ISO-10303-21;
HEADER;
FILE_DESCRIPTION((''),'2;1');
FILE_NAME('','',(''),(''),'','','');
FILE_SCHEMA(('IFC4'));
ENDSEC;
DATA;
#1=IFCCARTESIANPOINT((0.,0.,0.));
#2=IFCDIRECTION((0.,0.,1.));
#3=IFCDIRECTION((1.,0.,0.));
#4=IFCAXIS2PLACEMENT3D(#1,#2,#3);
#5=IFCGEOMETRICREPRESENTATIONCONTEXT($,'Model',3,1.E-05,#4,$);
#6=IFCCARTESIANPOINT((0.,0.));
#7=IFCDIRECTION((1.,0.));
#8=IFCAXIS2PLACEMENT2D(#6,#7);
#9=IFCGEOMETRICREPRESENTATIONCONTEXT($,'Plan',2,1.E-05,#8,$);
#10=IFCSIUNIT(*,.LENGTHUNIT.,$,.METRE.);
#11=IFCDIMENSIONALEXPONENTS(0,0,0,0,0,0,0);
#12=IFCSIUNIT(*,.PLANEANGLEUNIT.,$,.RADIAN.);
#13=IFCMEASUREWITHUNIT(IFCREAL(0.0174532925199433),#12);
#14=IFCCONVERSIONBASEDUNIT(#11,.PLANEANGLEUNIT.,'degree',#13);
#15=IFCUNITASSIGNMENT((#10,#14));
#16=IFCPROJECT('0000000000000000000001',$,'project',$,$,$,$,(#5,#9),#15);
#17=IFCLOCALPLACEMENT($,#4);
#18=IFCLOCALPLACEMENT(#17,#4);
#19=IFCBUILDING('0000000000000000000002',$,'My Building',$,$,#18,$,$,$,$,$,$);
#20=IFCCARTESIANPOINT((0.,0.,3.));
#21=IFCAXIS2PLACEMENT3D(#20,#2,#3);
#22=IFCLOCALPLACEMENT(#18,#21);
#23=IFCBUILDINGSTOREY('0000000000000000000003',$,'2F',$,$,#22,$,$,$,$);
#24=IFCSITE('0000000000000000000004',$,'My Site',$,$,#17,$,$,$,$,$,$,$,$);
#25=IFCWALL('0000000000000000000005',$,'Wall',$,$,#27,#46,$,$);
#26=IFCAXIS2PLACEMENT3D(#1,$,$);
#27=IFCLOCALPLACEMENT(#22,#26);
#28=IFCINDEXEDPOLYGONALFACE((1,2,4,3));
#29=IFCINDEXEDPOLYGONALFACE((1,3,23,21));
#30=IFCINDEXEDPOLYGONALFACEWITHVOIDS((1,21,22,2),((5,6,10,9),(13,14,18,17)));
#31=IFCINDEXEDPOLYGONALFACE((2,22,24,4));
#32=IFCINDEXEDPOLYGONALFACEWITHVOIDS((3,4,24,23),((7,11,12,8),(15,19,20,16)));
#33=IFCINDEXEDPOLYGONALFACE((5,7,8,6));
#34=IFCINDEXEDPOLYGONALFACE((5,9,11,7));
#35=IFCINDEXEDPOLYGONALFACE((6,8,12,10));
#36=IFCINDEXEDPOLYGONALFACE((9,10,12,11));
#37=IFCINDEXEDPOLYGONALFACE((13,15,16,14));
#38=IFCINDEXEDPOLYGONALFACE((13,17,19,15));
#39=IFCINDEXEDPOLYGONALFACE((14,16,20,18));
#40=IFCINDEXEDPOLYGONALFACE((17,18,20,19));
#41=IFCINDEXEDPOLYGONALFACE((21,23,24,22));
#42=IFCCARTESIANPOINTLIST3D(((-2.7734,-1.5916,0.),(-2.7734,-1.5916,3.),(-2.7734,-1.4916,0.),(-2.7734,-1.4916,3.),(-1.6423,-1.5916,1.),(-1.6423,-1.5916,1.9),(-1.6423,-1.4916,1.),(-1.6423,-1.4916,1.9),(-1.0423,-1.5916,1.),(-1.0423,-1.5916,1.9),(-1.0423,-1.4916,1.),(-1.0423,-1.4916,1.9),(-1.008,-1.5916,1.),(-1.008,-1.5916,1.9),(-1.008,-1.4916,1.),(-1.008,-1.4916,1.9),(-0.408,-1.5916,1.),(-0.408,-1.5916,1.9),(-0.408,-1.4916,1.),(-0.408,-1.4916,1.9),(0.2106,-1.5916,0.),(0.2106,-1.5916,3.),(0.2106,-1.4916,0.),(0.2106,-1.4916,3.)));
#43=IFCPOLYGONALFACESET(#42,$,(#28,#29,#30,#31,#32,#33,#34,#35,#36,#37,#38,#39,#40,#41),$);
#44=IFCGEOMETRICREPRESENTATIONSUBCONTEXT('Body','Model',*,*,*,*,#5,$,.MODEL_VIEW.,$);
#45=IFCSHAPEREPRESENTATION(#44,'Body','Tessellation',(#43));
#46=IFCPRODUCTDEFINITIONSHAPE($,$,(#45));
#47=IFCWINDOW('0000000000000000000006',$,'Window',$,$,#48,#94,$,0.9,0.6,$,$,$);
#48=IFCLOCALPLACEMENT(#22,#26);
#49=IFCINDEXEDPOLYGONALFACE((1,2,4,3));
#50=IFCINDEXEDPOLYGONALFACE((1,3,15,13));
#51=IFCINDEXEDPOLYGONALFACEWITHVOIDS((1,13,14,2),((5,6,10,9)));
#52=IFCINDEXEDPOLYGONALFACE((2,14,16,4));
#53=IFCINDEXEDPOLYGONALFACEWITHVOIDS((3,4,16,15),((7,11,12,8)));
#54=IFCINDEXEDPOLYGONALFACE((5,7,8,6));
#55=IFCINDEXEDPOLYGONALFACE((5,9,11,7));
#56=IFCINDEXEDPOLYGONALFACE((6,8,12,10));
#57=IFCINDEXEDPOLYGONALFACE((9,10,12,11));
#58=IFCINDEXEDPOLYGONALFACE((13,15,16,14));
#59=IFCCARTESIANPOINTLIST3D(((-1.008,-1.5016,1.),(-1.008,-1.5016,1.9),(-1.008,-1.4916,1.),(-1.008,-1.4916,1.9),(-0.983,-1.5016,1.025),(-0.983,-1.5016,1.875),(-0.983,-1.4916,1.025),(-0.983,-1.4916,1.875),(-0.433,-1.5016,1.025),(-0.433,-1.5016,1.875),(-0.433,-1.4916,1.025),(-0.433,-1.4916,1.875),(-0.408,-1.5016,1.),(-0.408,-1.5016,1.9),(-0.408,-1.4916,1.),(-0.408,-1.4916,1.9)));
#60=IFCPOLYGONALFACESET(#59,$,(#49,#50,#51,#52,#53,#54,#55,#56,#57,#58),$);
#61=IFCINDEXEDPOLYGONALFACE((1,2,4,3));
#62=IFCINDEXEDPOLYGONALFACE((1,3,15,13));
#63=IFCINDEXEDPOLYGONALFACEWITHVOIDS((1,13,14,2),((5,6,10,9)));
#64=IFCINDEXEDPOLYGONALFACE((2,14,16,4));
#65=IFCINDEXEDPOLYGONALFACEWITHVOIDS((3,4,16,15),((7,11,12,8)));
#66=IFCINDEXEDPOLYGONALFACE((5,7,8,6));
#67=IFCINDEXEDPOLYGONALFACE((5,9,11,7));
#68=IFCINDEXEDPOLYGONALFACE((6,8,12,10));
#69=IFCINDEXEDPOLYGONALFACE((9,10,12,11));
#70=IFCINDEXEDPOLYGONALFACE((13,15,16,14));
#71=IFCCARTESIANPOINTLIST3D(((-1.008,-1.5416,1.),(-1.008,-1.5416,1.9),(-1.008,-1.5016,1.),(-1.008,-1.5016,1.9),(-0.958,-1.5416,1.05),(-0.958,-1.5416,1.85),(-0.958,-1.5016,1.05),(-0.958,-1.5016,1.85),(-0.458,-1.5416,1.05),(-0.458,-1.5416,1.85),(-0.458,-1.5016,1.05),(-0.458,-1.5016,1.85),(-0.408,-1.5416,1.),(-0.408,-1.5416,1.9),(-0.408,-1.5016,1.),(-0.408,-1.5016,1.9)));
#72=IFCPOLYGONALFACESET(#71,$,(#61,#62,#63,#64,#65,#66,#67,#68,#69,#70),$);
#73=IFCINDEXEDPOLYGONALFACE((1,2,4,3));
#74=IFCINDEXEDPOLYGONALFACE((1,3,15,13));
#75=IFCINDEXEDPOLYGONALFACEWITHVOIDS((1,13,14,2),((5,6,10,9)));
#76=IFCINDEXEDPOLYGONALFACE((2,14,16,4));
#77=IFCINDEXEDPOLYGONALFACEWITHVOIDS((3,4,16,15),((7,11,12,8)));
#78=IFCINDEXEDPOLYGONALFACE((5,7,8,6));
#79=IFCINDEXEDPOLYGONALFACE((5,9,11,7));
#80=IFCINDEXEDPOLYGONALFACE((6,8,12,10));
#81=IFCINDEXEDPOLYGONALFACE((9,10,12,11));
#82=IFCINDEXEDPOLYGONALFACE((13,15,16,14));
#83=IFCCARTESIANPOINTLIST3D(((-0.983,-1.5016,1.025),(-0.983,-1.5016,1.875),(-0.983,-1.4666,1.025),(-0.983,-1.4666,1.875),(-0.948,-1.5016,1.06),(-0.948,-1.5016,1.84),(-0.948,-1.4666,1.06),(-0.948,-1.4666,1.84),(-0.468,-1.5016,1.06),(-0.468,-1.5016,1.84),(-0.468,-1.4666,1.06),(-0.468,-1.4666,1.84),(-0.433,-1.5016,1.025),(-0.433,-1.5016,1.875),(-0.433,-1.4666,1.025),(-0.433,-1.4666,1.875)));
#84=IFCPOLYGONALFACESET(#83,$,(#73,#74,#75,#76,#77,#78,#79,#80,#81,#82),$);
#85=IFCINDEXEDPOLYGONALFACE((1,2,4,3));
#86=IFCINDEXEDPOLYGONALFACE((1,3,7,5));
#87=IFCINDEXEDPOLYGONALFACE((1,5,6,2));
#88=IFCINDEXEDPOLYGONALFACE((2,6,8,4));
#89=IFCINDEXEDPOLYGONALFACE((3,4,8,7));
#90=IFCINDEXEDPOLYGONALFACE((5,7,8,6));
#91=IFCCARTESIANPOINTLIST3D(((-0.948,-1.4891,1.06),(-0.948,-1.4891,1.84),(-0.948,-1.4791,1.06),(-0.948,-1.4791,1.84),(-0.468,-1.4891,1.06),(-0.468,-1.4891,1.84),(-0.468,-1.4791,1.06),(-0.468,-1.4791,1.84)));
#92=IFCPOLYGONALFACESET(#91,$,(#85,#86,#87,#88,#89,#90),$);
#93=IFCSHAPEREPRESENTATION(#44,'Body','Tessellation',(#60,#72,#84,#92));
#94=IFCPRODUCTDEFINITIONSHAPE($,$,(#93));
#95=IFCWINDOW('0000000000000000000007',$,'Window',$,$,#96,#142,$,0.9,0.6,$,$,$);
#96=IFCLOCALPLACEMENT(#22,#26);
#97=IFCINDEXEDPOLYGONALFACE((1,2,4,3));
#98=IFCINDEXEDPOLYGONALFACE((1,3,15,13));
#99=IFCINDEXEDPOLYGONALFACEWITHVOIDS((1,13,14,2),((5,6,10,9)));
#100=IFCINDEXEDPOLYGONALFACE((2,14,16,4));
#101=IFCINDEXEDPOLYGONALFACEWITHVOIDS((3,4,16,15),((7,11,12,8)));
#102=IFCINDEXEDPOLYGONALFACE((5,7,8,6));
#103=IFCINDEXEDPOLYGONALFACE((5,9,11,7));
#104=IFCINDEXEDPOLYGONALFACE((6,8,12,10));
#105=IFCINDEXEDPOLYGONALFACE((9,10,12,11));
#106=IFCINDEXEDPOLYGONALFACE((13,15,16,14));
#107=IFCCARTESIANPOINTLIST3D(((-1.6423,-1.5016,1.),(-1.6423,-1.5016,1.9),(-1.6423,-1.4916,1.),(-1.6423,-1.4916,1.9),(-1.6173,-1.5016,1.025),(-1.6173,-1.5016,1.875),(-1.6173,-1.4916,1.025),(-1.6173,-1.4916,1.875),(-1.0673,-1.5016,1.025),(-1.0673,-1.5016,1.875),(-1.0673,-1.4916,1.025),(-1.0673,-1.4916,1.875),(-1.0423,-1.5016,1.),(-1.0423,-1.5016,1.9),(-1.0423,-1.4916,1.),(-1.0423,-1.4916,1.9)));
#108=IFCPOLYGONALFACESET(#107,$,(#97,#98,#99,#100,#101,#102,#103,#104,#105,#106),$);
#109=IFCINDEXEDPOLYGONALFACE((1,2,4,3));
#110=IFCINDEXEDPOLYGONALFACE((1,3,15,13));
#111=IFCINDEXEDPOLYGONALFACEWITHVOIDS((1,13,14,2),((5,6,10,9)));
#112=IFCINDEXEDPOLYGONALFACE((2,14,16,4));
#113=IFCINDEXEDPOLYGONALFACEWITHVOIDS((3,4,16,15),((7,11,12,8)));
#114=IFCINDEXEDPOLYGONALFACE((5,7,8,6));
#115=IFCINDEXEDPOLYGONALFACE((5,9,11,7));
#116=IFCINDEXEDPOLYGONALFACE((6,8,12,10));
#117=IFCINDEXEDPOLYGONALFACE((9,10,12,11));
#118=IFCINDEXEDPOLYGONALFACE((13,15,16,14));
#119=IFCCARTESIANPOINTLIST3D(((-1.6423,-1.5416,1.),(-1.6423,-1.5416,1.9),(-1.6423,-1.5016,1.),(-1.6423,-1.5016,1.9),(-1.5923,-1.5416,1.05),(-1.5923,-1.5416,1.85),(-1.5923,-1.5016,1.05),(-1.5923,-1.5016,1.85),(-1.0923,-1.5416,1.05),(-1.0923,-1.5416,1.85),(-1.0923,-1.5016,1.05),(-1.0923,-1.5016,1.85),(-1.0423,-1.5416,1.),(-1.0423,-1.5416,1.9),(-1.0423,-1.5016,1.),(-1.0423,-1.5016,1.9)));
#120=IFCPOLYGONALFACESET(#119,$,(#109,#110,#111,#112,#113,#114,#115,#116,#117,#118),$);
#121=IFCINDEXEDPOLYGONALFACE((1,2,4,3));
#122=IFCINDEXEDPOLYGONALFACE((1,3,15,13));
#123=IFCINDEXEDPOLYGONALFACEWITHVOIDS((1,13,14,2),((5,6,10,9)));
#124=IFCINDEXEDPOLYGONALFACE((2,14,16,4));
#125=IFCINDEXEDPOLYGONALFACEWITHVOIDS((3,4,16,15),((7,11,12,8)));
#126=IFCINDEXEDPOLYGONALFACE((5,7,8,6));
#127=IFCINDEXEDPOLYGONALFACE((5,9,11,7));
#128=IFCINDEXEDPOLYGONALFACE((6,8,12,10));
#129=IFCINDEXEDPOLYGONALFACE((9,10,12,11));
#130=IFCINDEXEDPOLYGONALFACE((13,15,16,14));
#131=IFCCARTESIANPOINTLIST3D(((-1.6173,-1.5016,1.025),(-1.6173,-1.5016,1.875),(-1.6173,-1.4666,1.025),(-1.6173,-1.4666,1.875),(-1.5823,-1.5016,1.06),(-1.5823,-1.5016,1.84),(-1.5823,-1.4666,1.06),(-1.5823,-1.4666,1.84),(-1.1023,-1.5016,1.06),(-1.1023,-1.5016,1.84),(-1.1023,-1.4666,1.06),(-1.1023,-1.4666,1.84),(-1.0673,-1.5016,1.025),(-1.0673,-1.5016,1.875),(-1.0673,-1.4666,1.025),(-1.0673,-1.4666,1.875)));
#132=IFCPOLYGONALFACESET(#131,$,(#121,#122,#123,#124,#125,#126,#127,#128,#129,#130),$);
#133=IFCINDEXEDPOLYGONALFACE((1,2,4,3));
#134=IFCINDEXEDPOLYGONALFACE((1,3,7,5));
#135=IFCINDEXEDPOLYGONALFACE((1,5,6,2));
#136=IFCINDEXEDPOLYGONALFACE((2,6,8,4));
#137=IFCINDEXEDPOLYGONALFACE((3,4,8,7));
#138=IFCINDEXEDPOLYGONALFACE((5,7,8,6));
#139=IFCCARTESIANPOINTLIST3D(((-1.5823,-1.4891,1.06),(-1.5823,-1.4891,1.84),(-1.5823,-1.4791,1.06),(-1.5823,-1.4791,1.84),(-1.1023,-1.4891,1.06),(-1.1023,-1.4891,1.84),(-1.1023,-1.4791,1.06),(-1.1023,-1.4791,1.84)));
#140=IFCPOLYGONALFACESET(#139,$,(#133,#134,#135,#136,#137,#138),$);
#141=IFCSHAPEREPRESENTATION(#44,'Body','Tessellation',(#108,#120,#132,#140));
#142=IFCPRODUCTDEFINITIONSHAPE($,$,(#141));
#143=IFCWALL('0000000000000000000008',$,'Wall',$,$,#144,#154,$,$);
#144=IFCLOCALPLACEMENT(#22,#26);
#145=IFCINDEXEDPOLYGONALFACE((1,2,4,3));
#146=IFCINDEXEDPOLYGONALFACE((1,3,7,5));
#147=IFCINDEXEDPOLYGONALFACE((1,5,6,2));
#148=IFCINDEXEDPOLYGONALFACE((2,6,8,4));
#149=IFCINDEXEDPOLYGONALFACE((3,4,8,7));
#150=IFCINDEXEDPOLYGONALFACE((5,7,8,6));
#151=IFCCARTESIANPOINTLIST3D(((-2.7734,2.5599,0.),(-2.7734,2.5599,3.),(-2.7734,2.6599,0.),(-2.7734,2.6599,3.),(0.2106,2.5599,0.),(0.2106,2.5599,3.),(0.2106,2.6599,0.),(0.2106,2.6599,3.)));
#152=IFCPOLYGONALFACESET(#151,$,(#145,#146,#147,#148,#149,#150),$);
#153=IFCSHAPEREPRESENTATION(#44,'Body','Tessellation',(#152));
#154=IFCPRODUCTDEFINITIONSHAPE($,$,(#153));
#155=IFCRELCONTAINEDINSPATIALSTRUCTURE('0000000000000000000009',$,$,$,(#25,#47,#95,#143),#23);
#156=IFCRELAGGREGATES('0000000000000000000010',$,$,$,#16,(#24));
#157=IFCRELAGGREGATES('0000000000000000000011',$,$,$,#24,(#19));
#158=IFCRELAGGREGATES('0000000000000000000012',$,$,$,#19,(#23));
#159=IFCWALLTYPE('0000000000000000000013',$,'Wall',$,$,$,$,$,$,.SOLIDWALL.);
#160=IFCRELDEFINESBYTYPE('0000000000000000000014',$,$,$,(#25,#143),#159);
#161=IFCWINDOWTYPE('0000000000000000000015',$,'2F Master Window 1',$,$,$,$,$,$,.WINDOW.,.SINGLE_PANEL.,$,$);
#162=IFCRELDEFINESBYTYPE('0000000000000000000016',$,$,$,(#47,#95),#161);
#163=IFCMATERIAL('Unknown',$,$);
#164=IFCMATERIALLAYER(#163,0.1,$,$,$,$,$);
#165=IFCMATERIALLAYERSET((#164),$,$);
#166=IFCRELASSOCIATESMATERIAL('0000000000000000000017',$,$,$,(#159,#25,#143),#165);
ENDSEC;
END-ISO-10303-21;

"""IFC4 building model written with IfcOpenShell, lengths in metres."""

from ifc_helpers import new_model, entity, si_unit, converted_unit, frame, origin_with_axes, origin_2d_with_axis, place, context, subcontext, project, spatial, line, indexed_curve, outline, extrude, shape, source, transform, mapped, material, layer, layer_set, layer_usage, type_object, type_shapes, element, fill, save


model = new_model("IFC4")

# Units and contexts
model_context = context("Model", 3, precision=1e-05, world=origin_with_axes())
plan_context = context("Plan", 2, precision=1e-05, world=origin_2d_with_axis())
body_context_1 = subcontext(model_context, "Body", "Model", "MODEL_VIEW")
body_context_2 = subcontext(plan_context, "Body", "Plan", "PLAN_VIEW")
ifc_project = project(units=[si_unit("LENGTHUNIT", "METRE"), converted_unit("PLANEANGLEUNIT", "degree", entity("IfcReal", 0.0174532925199433), si_unit("PLANEANGLEUNIT", "RADIAN"), dimensions=[0, 0, 0, 0, 0, 0, 0])], contexts=[model_context, plan_context])

# Site, building, storey
site_placement = place(None, origin_with_axes())
site = spatial("IfcSite", under=ifc_project, at=site_placement, Name="My Site")
building_placement = place(site_placement, origin_with_axes())
building = spatial("IfcBuilding", under=site, at=building_placement, Name="My Building")
storey_placement = place(building_placement, frame((0.0, 0.0, 3.0), z_axis=(0.0, 0.0, 1.0), x_axis=(1.0, 0.0, 0.0)))
storey = spatial("IfcBuildingStorey", under=building, at=storey_placement, Name="2F")

# Shared definitions
ifc_material = material(Name="Unknown")

# Shared definitions
ifc_layer = layer(ifc_material, 0.1)
ifc_layer_set = layer_set([ifc_layer])
wall_type = type_object("IfcWallType", Name="Wall", PredefinedType="SOLIDWALL", material=ifc_layer_set)

# Wall, openings, windows
ifc_layer_usage_1 = layer_usage(ifc_layer_set, "AXIS2", "POSITIVE", 0.0)
wall_1_placement = place(storey_placement, frame((-2.7734, -1.5916, 0.0), z_axis=(0.0, 0.0, 1.0), x_axis=(1.0, 0.0, 0.0)))
wall_1 = element("IfcWall", 1, at=wall_1_placement, inside=storey, type_object=wall_type, material=ifc_layer_usage_1, Name="Wall", context=body_context_1, shape_type="SweptSolid", body=[
    extrude(outline(indexed_curve([(0.0, 0.0), (0.0, 0.1), (2.984, 0.1), (2.984, 0.0)], segments=[line(1, 2, 3, 4, 1)])), origin_with_axes(), (0.0, 0.0, 1.0), 3.0),
])
shared_shape_1 = source(origin_with_axes(), body_context_1, "Body", "SweptSolid", [
    extrude(outline(indexed_curve([(0.0, 0.0), (0.6, 0.0), (0.6, 0.9), (0.0, 0.9)], segments=[line(1, 2, 3, 4, 1)])), frame((0.0, -0.6, 0.0), z_axis=(0.0, -1.0, 0.0), x_axis=(1.0, 0.0, 0.0)), (0.0, 0.0, -1.0), 1.2),
])
opening_1_placement = place(wall_1_placement, frame((1.7654, 0.0, 1.0), z_axis=(0.0, 0.0, 1.0), x_axis=(1.0, 0.0, 0.0)))
opening_1 = element("IfcOpeningElement", 2, at=opening_1_placement, cuts=wall_1, PredefinedType="OPENING", context=body_context_1, shape_type="MappedRepresentation", body=[
    mapped(shared_shape_1, transform((0.0, 0.0, 0.0), x_axis=(1.0, 0.0, 0.0), y_axis=(0.0, 1.0, 0.0), z_axis=(0.0, 0.0, 1.0), scale=1.0)),
])
opening_2_placement = place(wall_1_placement, frame((1.1311, 0.0, 1.0), z_axis=(0.0, 0.0, 1.0), x_axis=(1.0, 0.0, 0.0)))
opening_2 = element("IfcOpeningElement", 3, at=opening_2_placement, cuts=wall_1, PredefinedType="OPENING", context=body_context_1, shape_type="MappedRepresentation", body=[
    mapped(shared_shape_1, transform((0.0, 0.0, 0.0), x_axis=(1.0, 0.0, 0.0), y_axis=(0.0, 1.0, 0.0), z_axis=(0.0, 0.0, 1.0), scale=1.0)),
])
window_type_1 = type_object("IfcWindowType", Name="2F Master Window 1", PartitioningType="SINGLE_PANEL", PredefinedType="WINDOW")
shared_shape_2 = source(origin_with_axes(), body_context_1, "Body", "SweptSolid", [
    extrude(outline(indexed_curve([(0.0, 0.0), (0.6, 0.0), (0.6, 0.9), (0.0, 0.9)], segments=[line(1, 2, 3, 4, 1)]), holes=[indexed_curve([(0.025, 0.025), (0.575, 0.025), (0.575, 0.875), (0.025, 0.875)], segments=[line(1, 2, 3, 4, 1)])]), frame((0.0, 0.09, 0.0), z_axis=(0.0, -1.0, 0.0), x_axis=(1.0, 0.0, 0.0)), (0.0, 0.0, -1.0), 0.01),
    extrude(outline(indexed_curve([(0.0, 0.0), (0.6, 0.0), (0.6, 0.9), (0.0, 0.9)], segments=[line(1, 2, 3, 4, 1)]), holes=[indexed_curve([(0.05, 0.05), (0.55, 0.05), (0.55, 0.85), (0.05, 0.85)], segments=[line(1, 2, 3, 4, 1)])]), frame((0.0, 0.05, 0.0), z_axis=(0.0, -1.0, 0.0), x_axis=(1.0, 0.0, 0.0)), (0.0, 0.0, -1.0), 0.04),
    extrude(outline(indexed_curve([(0.0, 0.0), (0.55, 0.0), (0.55, 0.85), (0.0, 0.85)], segments=[line(1, 2, 3, 4, 1)]), holes=[indexed_curve([(0.035, 0.035), (0.515, 0.035), (0.515, 0.815), (0.035, 0.815)], segments=[line(1, 2, 3, 4, 1)])]), frame((0.025, 0.09, 0.025), z_axis=(0.0, -1.0, 0.0), x_axis=(1.0, 0.0, 0.0)), (0.0, 0.0, -1.0), 0.035),
    extrude(outline(indexed_curve([(0.035, 0.035), (0.515, 0.035), (0.515, 0.815), (0.035, 0.815)], segments=[line(1, 2, 3, 4, 1)])), frame((0.025, 0.1025, 0.025), z_axis=(0.0, -1.0, 0.0), x_axis=(1.0, 0.0, 0.0)), (0.0, 0.0, -1.0), 0.01),
])
shared_shape_3 = source(origin_with_axes(), body_context_2, "Body", "Curve2D", [
    entity("IfcIndexedPolyCurve", entity("IfcCartesianPointList2D", [[0.05, 0.05], [0.55, 0.05]])),
    entity("IfcIndexedPolyCurve", entity("IfcCartesianPointList2D", [[0.0, 0.1], [0.025, 0.1], [0.025, 0.09], [0.05, 0.09], [0.05, 0.05], [0.0, 0.05]]), [entity("IfcLineIndex", [1, 2, 3, 4, 5, 6, 1])]),
    entity("IfcIndexedPolyCurve", entity("IfcCartesianPointList2D", [[0.6, 0.1], [0.575, 0.1], [0.575, 0.09], [0.55, 0.09], [0.55, 0.05], [0.6, 0.05]]), [entity("IfcLineIndex", [1, 2, 3, 4, 5, 6, 1])]),
    entity("IfcIndexedPolyCurve", entity("IfcCartesianPointList2D", [[0.025, 0.09], [0.06, 0.09], [0.06, 0.125], [0.025, 0.125]]), [entity("IfcLineIndex", [1, 2, 3, 4, 1])]),
    entity("IfcIndexedPolyCurve", entity("IfcCartesianPointList2D", [[0.575, 0.09], [0.54, 0.09], [0.54, 0.125], [0.575, 0.125]]), [entity("IfcLineIndex", [1, 2, 3, 4, 1])]),
    entity("IfcIndexedPolyCurve", entity("IfcCartesianPointList2D", [[0.06, 0.09], [0.54, 0.09]])),
    entity("IfcIndexedPolyCurve", entity("IfcCartesianPointList2D", [[0.06, 0.125], [0.54, 0.125]])),
    entity("IfcIndexedPolyCurve", entity("IfcCartesianPointList2D", [[0.06, 0.1075], [0.54, 0.1075]])),
])
type_shapes(window_type_1, [shared_shape_2, shared_shape_3])
window_1_placement = place(opening_1_placement, origin_with_axes())
window_1 = element("IfcWindow", 4, at=window_1_placement, inside=storey, type_object=window_type_1, Name="Window", OverallHeight=0.9, OverallWidth=0.6, shapes=[
    shape(body_context_1, "Body", "MappedRepresentation", [mapped(shared_shape_2, transform((0.0, 0.0, 0.0), x_axis=(1.0, 0.0, 0.0), y_axis=(0.0, 1.0, 0.0), z_axis=(0.0, 0.0, 1.0), scale=1.0))]),
    shape(body_context_2, "Body", "MappedRepresentation", [mapped(shared_shape_3, transform((0.0, 0.0, 0.0), x_axis=(1.0, 0.0, 0.0), y_axis=(0.0, 1.0, 0.0), z_axis=(0.0, 0.0, 1.0), scale=1.0))]),
])
fill(opening_1, window_1)
window_2_placement = place(opening_2_placement, origin_with_axes())
window_2 = element("IfcWindow", 5, at=window_2_placement, inside=storey, type_object=window_type_1, Name="Window", OverallHeight=0.9, OverallWidth=0.6, shapes=[
    shape(body_context_1, "Body", "MappedRepresentation", [mapped(shared_shape_2, transform((0.0, 0.0, 0.0), x_axis=(1.0, 0.0, 0.0), y_axis=(0.0, 1.0, 0.0), z_axis=(0.0, 0.0, 1.0), scale=1.0))]),
    shape(body_context_2, "Body", "MappedRepresentation", [mapped(shared_shape_3, transform((0.0, 0.0, 0.0), x_axis=(1.0, 0.0, 0.0), y_axis=(0.0, 1.0, 0.0), z_axis=(0.0, 0.0, 1.0), scale=1.0))]),
])
fill(opening_2, window_2)

# Wall
ifc_layer_usage_2 = layer_usage(ifc_layer_set, "AXIS2", "POSITIVE", 0.0)
wall_2_placement = place(storey_placement, frame((-2.7734, 2.5599, 0.0), z_axis=(0.0, 0.0, 1.0), x_axis=(1.0, 0.0, 0.0)))
element("IfcWall", 6, at=wall_2_placement, inside=storey, type_object=wall_type, material=ifc_layer_usage_2, Name="Wall", context=body_context_1, shape_type="SweptSolid", body=[
    extrude(outline(indexed_curve([(0.0, 0.0), (0.0, 0.1), (2.984, 0.1), (2.984, 0.0)], segments=[line(1, 2, 3, 4, 1)])), origin_with_axes(), (0.0, 0.0, 1.0), 3.0),
])

save(model, "model.ifc")
